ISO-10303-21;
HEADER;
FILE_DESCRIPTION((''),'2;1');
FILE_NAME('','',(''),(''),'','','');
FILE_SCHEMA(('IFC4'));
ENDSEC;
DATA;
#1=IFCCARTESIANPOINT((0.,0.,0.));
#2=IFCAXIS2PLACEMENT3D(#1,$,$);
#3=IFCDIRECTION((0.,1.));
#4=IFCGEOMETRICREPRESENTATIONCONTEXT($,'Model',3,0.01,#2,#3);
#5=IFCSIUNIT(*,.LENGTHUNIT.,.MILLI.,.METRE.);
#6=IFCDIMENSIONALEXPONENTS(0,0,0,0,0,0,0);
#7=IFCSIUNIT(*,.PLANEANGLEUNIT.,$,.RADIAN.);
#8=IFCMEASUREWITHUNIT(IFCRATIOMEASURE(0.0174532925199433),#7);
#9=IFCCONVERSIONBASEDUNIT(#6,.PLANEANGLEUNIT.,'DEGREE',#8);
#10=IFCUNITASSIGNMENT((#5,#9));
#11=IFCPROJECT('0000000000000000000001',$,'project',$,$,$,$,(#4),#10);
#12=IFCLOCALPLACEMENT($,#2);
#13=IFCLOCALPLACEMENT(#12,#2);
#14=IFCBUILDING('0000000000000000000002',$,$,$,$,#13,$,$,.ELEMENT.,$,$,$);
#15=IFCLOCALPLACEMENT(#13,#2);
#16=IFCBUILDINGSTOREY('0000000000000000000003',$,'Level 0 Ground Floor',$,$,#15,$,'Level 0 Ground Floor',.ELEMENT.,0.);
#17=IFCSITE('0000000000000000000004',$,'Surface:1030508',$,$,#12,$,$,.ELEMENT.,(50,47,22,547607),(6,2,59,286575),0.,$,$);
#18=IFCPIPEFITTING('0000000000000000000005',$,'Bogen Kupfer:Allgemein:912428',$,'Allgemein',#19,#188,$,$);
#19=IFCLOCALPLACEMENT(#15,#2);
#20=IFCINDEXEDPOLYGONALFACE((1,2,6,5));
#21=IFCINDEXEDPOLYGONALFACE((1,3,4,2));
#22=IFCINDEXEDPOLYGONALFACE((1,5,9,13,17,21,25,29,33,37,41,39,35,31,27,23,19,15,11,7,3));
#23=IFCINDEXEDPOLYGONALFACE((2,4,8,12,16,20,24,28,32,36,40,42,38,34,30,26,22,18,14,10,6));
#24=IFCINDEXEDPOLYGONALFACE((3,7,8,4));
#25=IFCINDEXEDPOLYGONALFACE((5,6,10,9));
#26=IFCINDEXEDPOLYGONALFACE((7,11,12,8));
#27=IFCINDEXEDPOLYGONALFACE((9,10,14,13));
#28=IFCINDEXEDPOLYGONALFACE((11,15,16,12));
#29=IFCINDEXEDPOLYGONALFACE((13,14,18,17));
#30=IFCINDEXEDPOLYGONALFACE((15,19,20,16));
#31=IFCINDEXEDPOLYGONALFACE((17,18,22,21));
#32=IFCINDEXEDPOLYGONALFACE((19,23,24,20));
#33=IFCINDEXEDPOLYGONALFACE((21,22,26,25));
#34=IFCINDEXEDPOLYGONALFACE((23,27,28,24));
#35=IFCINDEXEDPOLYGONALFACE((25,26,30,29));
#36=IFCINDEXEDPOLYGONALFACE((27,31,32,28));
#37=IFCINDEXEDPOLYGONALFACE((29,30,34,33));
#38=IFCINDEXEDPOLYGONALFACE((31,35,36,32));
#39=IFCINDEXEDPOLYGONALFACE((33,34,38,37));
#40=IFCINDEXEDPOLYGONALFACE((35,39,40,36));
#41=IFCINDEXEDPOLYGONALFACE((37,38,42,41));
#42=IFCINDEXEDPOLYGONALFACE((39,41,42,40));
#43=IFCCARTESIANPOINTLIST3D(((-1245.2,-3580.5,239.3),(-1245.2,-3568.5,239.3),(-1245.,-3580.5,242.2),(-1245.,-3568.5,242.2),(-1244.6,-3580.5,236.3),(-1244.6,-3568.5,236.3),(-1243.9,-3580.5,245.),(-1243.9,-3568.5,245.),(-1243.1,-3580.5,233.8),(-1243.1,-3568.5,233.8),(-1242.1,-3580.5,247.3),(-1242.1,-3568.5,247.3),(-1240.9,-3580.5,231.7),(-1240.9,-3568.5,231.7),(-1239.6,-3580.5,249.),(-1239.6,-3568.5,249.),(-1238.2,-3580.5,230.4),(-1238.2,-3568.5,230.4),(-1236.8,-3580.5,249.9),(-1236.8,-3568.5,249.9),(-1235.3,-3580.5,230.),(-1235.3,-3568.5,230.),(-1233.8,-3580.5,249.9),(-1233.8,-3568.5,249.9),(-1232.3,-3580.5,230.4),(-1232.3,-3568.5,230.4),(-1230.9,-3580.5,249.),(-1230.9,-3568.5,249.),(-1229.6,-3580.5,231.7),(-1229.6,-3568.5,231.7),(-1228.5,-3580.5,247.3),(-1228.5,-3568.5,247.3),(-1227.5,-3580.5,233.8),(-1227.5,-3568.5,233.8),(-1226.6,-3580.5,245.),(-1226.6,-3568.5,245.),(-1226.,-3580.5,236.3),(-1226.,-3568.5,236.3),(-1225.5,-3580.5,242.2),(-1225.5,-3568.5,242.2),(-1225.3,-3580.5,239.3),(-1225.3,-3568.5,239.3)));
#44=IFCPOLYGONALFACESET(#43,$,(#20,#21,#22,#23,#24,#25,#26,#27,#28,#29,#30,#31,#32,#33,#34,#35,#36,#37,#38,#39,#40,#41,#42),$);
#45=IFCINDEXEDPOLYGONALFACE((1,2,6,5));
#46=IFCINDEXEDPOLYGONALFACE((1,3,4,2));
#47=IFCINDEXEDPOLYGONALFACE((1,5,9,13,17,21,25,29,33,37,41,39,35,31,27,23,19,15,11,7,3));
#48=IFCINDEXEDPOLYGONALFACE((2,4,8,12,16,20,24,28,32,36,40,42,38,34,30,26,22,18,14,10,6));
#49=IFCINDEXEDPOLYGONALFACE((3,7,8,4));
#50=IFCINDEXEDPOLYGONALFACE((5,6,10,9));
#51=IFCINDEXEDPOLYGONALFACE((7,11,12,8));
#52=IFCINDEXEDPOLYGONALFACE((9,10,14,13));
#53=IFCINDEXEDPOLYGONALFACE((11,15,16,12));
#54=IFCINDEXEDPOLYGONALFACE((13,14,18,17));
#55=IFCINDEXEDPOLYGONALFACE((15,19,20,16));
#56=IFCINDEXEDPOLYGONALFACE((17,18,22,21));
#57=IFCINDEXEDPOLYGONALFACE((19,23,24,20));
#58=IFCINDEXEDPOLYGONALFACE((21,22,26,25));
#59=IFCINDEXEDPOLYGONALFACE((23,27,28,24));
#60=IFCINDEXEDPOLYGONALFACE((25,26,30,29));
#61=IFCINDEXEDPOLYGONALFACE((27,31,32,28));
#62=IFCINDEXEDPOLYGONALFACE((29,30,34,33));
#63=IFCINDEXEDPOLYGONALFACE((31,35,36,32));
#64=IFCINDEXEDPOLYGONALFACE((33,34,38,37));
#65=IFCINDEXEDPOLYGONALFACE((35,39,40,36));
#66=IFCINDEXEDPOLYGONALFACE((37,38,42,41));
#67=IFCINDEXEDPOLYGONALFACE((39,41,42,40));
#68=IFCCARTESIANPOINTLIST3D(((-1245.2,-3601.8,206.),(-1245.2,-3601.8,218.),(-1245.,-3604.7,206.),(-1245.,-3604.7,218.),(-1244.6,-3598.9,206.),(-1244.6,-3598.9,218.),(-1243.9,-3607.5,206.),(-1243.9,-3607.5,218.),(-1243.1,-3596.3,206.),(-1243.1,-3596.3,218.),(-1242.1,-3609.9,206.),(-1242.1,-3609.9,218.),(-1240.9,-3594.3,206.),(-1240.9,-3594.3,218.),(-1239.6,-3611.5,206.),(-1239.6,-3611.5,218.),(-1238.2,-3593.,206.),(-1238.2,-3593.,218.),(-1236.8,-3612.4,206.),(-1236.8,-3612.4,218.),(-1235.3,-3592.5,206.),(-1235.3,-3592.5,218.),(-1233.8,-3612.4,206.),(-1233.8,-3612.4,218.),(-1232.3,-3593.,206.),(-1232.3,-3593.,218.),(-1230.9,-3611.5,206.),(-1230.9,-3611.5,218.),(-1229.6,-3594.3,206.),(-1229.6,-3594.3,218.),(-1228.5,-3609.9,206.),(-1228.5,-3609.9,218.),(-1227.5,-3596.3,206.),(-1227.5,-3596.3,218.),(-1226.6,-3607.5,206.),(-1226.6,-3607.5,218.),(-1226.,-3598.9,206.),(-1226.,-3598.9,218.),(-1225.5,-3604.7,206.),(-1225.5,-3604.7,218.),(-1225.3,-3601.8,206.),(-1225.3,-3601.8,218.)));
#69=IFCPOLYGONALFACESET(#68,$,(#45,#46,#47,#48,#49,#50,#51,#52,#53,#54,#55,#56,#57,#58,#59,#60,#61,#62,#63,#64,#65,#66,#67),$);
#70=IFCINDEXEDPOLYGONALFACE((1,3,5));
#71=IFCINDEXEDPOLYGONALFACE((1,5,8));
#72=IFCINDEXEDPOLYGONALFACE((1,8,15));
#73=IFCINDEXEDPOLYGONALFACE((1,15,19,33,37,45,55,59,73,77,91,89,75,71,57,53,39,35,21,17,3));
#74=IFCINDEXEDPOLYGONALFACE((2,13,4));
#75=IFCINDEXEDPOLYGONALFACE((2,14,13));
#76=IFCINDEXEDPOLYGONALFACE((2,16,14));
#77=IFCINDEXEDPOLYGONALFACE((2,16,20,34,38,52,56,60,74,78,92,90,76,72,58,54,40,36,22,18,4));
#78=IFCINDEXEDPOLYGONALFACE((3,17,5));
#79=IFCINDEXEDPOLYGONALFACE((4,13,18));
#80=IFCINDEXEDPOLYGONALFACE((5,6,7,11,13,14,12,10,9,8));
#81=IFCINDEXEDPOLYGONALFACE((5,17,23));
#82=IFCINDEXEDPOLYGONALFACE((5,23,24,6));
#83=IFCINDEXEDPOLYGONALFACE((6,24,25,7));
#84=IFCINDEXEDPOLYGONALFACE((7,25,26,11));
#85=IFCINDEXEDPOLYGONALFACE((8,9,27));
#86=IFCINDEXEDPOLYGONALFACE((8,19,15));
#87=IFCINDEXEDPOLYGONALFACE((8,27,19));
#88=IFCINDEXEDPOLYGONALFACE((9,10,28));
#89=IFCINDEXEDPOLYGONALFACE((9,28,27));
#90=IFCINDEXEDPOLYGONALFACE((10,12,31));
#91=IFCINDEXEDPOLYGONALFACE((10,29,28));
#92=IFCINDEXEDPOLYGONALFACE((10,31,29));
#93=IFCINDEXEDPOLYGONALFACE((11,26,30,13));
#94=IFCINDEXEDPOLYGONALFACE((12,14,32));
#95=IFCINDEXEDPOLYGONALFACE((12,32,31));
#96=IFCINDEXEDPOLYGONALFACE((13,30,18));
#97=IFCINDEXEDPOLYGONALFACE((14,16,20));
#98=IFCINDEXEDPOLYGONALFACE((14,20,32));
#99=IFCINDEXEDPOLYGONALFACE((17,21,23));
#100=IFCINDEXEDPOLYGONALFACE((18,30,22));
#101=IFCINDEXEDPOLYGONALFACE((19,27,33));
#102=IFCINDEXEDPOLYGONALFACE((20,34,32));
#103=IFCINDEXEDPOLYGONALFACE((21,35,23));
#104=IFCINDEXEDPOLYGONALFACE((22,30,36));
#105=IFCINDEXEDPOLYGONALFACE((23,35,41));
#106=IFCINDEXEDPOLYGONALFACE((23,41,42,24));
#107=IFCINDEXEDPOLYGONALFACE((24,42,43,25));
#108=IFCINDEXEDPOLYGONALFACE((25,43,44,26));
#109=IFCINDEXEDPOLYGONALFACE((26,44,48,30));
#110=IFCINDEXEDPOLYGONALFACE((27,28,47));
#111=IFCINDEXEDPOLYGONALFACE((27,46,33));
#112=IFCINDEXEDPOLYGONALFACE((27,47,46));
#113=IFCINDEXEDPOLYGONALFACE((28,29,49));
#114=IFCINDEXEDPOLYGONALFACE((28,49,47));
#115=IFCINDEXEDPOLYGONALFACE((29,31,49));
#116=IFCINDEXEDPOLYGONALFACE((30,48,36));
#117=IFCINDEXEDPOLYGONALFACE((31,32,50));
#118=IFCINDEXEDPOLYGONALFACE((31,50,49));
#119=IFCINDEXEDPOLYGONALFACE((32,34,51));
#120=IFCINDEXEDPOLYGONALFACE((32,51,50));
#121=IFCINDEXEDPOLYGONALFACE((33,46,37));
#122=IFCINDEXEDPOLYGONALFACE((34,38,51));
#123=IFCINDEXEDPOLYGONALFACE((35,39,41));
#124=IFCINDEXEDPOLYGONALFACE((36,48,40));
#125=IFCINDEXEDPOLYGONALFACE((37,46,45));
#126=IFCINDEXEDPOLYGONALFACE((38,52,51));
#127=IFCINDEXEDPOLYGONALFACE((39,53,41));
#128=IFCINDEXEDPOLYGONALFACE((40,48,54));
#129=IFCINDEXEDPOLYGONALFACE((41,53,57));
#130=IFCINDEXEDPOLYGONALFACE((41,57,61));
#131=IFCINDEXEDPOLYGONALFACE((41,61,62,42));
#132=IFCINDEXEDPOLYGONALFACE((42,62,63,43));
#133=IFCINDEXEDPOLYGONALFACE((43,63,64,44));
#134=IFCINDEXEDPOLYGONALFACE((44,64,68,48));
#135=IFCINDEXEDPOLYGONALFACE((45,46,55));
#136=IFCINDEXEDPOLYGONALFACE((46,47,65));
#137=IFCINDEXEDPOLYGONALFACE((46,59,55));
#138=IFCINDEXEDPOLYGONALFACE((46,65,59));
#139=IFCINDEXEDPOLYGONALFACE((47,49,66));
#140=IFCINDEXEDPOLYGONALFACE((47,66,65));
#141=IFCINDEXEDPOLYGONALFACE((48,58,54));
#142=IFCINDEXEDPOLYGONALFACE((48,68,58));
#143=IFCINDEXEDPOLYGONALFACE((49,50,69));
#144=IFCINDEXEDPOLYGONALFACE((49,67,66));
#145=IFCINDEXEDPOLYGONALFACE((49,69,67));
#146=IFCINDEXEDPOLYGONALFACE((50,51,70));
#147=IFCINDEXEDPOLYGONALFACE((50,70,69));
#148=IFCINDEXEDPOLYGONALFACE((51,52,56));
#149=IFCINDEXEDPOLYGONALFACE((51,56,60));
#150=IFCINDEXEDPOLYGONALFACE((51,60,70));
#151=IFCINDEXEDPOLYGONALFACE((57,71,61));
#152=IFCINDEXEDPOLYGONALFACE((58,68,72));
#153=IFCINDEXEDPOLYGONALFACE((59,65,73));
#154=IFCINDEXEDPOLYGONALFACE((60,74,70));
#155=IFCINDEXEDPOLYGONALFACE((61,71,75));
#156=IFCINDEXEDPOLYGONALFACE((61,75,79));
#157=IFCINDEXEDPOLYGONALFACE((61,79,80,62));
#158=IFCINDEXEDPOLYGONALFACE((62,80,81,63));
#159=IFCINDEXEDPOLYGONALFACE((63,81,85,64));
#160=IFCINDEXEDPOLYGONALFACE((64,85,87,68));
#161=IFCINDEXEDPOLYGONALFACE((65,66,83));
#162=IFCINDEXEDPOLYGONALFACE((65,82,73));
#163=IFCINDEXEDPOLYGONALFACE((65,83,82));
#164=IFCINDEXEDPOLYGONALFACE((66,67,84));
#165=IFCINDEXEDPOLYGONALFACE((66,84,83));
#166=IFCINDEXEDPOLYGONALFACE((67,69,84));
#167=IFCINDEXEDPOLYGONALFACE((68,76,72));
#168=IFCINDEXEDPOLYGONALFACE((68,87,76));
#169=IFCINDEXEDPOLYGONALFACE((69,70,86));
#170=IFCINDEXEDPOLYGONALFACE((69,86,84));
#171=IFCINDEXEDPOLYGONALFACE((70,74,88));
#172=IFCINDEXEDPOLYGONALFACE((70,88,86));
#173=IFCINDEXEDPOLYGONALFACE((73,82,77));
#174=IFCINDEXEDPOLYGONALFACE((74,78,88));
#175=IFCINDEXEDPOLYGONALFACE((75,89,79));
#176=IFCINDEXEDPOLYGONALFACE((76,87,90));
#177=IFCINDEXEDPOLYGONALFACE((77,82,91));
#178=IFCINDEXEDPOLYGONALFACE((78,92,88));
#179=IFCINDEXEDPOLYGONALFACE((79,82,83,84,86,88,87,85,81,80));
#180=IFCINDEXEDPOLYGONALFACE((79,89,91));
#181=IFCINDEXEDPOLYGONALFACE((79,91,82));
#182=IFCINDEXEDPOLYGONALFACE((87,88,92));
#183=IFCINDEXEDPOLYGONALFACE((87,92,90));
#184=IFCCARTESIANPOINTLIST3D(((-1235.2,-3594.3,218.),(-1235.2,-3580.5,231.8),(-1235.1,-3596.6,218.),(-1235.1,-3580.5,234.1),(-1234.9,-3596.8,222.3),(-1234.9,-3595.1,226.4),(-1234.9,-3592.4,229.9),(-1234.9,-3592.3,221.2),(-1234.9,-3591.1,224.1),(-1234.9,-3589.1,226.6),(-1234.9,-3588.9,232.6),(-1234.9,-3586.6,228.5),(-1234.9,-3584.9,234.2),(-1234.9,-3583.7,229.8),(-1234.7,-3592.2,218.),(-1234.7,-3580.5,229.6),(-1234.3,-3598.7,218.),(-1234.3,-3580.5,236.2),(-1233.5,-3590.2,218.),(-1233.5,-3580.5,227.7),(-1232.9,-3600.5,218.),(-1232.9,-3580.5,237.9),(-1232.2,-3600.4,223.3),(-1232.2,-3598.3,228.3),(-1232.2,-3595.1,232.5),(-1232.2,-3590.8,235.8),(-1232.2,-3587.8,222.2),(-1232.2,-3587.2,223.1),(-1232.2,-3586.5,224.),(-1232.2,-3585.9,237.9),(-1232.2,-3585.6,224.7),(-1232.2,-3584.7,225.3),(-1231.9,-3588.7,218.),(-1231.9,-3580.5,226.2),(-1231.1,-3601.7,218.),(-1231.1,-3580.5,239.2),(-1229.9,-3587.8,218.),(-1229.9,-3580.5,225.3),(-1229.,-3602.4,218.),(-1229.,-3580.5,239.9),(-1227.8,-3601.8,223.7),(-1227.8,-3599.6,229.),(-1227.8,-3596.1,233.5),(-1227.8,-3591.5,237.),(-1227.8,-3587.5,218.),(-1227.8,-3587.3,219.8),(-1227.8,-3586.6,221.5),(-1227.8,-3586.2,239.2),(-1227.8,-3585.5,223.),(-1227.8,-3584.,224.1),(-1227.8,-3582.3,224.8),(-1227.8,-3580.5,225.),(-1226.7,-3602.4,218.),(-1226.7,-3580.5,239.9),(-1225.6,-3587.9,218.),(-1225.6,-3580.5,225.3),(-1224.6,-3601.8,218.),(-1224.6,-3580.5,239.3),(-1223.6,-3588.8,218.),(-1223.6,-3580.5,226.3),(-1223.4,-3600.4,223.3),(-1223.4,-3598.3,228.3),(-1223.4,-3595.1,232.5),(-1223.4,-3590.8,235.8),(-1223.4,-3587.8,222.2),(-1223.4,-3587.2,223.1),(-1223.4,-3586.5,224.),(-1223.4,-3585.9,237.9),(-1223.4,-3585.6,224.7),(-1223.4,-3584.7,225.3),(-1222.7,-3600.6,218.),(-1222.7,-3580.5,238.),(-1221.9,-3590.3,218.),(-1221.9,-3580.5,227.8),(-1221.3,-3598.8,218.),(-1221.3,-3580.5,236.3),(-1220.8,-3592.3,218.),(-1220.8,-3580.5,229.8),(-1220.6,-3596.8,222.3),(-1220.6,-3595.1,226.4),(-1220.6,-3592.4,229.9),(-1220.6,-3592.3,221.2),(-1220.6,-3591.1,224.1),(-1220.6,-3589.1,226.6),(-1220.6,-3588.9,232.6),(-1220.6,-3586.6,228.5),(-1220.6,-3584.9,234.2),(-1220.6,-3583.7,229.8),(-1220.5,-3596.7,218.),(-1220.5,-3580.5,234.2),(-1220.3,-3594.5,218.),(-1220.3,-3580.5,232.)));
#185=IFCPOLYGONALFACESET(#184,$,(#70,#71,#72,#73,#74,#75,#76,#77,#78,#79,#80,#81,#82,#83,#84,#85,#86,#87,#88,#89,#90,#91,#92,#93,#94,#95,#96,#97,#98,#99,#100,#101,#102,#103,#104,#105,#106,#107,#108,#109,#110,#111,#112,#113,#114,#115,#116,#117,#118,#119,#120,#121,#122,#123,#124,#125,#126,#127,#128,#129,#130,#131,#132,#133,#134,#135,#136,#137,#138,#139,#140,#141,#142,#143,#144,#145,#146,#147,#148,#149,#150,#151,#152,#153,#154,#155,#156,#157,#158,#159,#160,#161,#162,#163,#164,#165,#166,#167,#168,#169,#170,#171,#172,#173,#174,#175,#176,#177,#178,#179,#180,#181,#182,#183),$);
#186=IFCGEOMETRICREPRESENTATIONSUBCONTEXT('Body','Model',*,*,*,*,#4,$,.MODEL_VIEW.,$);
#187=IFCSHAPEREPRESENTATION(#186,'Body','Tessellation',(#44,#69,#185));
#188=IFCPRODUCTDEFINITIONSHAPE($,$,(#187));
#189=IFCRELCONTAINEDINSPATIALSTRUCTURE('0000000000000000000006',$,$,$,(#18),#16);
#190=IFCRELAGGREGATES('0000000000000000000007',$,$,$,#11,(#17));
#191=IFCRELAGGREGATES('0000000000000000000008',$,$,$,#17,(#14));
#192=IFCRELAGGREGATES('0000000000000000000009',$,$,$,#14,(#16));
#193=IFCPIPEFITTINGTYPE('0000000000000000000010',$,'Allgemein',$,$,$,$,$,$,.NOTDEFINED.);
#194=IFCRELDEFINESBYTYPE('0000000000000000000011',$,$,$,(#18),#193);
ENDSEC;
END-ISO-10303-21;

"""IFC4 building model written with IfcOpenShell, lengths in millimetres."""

from ifc_helpers import new_model, entity, si_unit, converted_unit, direction, frame, frame_2d, origin, place, context, subcontext, project, spatial, circle, extrude, source, transform, mapped, type_object, type_shapes, element, save


model = new_model("IFC4")

# Units and contexts
model_context = context("Model", 3, precision=0.01, world=origin(), true_north=direction((0.0, 1.0)))
body_context = subcontext(model_context, "Body", "Model", "MODEL_VIEW")
ifc_project = project(units=[si_unit("LENGTHUNIT", "METRE", prefix="MILLI"), converted_unit("PLANEANGLEUNIT", "DEGREE", entity("IfcRatioMeasure", 0.0174532925199433), si_unit("PLANEANGLEUNIT", "RADIAN"), dimensions=[0, 0, 0, 0, 0, 0, 0])], contexts=[model_context])

# Site, building, storey
site_placement = place(None, origin())
site = spatial("IfcSite", under=ifc_project, at=site_placement, Name="Surface:1030508", CompositionType="ELEMENT", RefLatitude=(50, 47, 22, 547607), RefLongitude=(6, 2, 59, 286575), RefElevation=0.0)
building_placement = place(site_placement, origin())
building = spatial("IfcBuilding", under=site, at=building_placement, CompositionType="ELEMENT")
storey_placement = place(building_placement, origin())
storey = spatial("IfcBuildingStorey", under=building, at=storey_placement, Name="Level 0 Ground Floor", LongName="Level 0 Ground Floor", CompositionType="ELEMENT", Elevation=0.0)

# Pipe fitting
pipe_fitting_type_1 = type_object("IfcPipeFittingType", Name="Allgemein", PredefinedType="NOTDEFINED")
ifc_direction_1 = entity("IfcDirection", [0.0, 0.0, -1.0])
trimmed_curve_1 = entity("IfcTrimmedCurve", entity("IfcCircle", entity("IfcAxis2Placement2D", entity("IfcCartesianPoint", [-14.5, 0.0]), entity("IfcDirection", [0.0, 1.0])), 14.5), [entity("IfcParameterValue", 270.0)], [entity("IfcParameterValue", 0.0)], True, "PARAMETER")
shared_shape_1 = source(origin(), body_context, "Body", "SolidModel", [
    extrude(circle(Radius=10.0, at=frame_2d((0.0, 0.0), x_axis=(1.0, 0.0))), frame((0.0, 22.0, 0.0), z_axis=(0.0, 1.0, 0.0), x_axis=(-1.0, 0.0, 0.0)), (0.0, 0.0, 1.0), 12.0),
    extrude(circle(Radius=10.0, at=frame_2d((0.0, 0.0), x_axis=(1.0, 0.0))), frame((-34.0, 0.0, 0.0), z_axis=(1.0, 0.0, 0.0), x_axis=(0.0, 1.0, 0.0)), (0.0, 0.0, 1.0), 12.0),
    entity("IfcSurfaceCurveSweptAreaSolid", entity("IfcCircleProfileDef", "AREA", None, entity("IfcAxis2Placement2D", entity("IfcCartesianPoint", [0.0, 7.5]), entity("IfcDirection", [1.0, 0.0])), 7.5), entity("IfcAxis2Placement3D", entity("IfcCartesianPoint", [-7.5, 22.0, 0.0]), ifc_direction_1, entity("IfcDirection", [1.0, 0.0, 0.0])), trimmed_curve_1, 0.0, 90.0, entity("IfcSurfaceOfLinearExtrusion", entity("IfcArbitraryOpenProfileDef", "CURVE", None, trimmed_curve_1), entity("IfcAxis2Placement3D", entity("IfcCartesianPoint", [0.0, 0.0, -304.8])), ifc_direction_1, 1.0)),
])
type_shapes(pipe_fitting_type_1, [shared_shape_1])
for number, where, z_axis, x_axis, name in (
    (1, (-1235.3, -3602.5, 240.0), (-1.0, 0.0, 0.0), (0.0, 0.0, 1.0), "Bogen Kupfer:Allgemein:912428"),
):
    element("IfcPipeFitting", number, at=place(storey_placement, frame(where, z_axis=z_axis, x_axis=x_axis)), inside=storey, type_object=pipe_fitting_type_1, Name=name, ObjectType="Allgemein", context=body_context, shape_type="MappedRepresentation", body=[
        mapped(shared_shape_1, transform((0.0, 0.0, 0.0), scale=1.0)),
    ])

save(model, "model.ifc")
